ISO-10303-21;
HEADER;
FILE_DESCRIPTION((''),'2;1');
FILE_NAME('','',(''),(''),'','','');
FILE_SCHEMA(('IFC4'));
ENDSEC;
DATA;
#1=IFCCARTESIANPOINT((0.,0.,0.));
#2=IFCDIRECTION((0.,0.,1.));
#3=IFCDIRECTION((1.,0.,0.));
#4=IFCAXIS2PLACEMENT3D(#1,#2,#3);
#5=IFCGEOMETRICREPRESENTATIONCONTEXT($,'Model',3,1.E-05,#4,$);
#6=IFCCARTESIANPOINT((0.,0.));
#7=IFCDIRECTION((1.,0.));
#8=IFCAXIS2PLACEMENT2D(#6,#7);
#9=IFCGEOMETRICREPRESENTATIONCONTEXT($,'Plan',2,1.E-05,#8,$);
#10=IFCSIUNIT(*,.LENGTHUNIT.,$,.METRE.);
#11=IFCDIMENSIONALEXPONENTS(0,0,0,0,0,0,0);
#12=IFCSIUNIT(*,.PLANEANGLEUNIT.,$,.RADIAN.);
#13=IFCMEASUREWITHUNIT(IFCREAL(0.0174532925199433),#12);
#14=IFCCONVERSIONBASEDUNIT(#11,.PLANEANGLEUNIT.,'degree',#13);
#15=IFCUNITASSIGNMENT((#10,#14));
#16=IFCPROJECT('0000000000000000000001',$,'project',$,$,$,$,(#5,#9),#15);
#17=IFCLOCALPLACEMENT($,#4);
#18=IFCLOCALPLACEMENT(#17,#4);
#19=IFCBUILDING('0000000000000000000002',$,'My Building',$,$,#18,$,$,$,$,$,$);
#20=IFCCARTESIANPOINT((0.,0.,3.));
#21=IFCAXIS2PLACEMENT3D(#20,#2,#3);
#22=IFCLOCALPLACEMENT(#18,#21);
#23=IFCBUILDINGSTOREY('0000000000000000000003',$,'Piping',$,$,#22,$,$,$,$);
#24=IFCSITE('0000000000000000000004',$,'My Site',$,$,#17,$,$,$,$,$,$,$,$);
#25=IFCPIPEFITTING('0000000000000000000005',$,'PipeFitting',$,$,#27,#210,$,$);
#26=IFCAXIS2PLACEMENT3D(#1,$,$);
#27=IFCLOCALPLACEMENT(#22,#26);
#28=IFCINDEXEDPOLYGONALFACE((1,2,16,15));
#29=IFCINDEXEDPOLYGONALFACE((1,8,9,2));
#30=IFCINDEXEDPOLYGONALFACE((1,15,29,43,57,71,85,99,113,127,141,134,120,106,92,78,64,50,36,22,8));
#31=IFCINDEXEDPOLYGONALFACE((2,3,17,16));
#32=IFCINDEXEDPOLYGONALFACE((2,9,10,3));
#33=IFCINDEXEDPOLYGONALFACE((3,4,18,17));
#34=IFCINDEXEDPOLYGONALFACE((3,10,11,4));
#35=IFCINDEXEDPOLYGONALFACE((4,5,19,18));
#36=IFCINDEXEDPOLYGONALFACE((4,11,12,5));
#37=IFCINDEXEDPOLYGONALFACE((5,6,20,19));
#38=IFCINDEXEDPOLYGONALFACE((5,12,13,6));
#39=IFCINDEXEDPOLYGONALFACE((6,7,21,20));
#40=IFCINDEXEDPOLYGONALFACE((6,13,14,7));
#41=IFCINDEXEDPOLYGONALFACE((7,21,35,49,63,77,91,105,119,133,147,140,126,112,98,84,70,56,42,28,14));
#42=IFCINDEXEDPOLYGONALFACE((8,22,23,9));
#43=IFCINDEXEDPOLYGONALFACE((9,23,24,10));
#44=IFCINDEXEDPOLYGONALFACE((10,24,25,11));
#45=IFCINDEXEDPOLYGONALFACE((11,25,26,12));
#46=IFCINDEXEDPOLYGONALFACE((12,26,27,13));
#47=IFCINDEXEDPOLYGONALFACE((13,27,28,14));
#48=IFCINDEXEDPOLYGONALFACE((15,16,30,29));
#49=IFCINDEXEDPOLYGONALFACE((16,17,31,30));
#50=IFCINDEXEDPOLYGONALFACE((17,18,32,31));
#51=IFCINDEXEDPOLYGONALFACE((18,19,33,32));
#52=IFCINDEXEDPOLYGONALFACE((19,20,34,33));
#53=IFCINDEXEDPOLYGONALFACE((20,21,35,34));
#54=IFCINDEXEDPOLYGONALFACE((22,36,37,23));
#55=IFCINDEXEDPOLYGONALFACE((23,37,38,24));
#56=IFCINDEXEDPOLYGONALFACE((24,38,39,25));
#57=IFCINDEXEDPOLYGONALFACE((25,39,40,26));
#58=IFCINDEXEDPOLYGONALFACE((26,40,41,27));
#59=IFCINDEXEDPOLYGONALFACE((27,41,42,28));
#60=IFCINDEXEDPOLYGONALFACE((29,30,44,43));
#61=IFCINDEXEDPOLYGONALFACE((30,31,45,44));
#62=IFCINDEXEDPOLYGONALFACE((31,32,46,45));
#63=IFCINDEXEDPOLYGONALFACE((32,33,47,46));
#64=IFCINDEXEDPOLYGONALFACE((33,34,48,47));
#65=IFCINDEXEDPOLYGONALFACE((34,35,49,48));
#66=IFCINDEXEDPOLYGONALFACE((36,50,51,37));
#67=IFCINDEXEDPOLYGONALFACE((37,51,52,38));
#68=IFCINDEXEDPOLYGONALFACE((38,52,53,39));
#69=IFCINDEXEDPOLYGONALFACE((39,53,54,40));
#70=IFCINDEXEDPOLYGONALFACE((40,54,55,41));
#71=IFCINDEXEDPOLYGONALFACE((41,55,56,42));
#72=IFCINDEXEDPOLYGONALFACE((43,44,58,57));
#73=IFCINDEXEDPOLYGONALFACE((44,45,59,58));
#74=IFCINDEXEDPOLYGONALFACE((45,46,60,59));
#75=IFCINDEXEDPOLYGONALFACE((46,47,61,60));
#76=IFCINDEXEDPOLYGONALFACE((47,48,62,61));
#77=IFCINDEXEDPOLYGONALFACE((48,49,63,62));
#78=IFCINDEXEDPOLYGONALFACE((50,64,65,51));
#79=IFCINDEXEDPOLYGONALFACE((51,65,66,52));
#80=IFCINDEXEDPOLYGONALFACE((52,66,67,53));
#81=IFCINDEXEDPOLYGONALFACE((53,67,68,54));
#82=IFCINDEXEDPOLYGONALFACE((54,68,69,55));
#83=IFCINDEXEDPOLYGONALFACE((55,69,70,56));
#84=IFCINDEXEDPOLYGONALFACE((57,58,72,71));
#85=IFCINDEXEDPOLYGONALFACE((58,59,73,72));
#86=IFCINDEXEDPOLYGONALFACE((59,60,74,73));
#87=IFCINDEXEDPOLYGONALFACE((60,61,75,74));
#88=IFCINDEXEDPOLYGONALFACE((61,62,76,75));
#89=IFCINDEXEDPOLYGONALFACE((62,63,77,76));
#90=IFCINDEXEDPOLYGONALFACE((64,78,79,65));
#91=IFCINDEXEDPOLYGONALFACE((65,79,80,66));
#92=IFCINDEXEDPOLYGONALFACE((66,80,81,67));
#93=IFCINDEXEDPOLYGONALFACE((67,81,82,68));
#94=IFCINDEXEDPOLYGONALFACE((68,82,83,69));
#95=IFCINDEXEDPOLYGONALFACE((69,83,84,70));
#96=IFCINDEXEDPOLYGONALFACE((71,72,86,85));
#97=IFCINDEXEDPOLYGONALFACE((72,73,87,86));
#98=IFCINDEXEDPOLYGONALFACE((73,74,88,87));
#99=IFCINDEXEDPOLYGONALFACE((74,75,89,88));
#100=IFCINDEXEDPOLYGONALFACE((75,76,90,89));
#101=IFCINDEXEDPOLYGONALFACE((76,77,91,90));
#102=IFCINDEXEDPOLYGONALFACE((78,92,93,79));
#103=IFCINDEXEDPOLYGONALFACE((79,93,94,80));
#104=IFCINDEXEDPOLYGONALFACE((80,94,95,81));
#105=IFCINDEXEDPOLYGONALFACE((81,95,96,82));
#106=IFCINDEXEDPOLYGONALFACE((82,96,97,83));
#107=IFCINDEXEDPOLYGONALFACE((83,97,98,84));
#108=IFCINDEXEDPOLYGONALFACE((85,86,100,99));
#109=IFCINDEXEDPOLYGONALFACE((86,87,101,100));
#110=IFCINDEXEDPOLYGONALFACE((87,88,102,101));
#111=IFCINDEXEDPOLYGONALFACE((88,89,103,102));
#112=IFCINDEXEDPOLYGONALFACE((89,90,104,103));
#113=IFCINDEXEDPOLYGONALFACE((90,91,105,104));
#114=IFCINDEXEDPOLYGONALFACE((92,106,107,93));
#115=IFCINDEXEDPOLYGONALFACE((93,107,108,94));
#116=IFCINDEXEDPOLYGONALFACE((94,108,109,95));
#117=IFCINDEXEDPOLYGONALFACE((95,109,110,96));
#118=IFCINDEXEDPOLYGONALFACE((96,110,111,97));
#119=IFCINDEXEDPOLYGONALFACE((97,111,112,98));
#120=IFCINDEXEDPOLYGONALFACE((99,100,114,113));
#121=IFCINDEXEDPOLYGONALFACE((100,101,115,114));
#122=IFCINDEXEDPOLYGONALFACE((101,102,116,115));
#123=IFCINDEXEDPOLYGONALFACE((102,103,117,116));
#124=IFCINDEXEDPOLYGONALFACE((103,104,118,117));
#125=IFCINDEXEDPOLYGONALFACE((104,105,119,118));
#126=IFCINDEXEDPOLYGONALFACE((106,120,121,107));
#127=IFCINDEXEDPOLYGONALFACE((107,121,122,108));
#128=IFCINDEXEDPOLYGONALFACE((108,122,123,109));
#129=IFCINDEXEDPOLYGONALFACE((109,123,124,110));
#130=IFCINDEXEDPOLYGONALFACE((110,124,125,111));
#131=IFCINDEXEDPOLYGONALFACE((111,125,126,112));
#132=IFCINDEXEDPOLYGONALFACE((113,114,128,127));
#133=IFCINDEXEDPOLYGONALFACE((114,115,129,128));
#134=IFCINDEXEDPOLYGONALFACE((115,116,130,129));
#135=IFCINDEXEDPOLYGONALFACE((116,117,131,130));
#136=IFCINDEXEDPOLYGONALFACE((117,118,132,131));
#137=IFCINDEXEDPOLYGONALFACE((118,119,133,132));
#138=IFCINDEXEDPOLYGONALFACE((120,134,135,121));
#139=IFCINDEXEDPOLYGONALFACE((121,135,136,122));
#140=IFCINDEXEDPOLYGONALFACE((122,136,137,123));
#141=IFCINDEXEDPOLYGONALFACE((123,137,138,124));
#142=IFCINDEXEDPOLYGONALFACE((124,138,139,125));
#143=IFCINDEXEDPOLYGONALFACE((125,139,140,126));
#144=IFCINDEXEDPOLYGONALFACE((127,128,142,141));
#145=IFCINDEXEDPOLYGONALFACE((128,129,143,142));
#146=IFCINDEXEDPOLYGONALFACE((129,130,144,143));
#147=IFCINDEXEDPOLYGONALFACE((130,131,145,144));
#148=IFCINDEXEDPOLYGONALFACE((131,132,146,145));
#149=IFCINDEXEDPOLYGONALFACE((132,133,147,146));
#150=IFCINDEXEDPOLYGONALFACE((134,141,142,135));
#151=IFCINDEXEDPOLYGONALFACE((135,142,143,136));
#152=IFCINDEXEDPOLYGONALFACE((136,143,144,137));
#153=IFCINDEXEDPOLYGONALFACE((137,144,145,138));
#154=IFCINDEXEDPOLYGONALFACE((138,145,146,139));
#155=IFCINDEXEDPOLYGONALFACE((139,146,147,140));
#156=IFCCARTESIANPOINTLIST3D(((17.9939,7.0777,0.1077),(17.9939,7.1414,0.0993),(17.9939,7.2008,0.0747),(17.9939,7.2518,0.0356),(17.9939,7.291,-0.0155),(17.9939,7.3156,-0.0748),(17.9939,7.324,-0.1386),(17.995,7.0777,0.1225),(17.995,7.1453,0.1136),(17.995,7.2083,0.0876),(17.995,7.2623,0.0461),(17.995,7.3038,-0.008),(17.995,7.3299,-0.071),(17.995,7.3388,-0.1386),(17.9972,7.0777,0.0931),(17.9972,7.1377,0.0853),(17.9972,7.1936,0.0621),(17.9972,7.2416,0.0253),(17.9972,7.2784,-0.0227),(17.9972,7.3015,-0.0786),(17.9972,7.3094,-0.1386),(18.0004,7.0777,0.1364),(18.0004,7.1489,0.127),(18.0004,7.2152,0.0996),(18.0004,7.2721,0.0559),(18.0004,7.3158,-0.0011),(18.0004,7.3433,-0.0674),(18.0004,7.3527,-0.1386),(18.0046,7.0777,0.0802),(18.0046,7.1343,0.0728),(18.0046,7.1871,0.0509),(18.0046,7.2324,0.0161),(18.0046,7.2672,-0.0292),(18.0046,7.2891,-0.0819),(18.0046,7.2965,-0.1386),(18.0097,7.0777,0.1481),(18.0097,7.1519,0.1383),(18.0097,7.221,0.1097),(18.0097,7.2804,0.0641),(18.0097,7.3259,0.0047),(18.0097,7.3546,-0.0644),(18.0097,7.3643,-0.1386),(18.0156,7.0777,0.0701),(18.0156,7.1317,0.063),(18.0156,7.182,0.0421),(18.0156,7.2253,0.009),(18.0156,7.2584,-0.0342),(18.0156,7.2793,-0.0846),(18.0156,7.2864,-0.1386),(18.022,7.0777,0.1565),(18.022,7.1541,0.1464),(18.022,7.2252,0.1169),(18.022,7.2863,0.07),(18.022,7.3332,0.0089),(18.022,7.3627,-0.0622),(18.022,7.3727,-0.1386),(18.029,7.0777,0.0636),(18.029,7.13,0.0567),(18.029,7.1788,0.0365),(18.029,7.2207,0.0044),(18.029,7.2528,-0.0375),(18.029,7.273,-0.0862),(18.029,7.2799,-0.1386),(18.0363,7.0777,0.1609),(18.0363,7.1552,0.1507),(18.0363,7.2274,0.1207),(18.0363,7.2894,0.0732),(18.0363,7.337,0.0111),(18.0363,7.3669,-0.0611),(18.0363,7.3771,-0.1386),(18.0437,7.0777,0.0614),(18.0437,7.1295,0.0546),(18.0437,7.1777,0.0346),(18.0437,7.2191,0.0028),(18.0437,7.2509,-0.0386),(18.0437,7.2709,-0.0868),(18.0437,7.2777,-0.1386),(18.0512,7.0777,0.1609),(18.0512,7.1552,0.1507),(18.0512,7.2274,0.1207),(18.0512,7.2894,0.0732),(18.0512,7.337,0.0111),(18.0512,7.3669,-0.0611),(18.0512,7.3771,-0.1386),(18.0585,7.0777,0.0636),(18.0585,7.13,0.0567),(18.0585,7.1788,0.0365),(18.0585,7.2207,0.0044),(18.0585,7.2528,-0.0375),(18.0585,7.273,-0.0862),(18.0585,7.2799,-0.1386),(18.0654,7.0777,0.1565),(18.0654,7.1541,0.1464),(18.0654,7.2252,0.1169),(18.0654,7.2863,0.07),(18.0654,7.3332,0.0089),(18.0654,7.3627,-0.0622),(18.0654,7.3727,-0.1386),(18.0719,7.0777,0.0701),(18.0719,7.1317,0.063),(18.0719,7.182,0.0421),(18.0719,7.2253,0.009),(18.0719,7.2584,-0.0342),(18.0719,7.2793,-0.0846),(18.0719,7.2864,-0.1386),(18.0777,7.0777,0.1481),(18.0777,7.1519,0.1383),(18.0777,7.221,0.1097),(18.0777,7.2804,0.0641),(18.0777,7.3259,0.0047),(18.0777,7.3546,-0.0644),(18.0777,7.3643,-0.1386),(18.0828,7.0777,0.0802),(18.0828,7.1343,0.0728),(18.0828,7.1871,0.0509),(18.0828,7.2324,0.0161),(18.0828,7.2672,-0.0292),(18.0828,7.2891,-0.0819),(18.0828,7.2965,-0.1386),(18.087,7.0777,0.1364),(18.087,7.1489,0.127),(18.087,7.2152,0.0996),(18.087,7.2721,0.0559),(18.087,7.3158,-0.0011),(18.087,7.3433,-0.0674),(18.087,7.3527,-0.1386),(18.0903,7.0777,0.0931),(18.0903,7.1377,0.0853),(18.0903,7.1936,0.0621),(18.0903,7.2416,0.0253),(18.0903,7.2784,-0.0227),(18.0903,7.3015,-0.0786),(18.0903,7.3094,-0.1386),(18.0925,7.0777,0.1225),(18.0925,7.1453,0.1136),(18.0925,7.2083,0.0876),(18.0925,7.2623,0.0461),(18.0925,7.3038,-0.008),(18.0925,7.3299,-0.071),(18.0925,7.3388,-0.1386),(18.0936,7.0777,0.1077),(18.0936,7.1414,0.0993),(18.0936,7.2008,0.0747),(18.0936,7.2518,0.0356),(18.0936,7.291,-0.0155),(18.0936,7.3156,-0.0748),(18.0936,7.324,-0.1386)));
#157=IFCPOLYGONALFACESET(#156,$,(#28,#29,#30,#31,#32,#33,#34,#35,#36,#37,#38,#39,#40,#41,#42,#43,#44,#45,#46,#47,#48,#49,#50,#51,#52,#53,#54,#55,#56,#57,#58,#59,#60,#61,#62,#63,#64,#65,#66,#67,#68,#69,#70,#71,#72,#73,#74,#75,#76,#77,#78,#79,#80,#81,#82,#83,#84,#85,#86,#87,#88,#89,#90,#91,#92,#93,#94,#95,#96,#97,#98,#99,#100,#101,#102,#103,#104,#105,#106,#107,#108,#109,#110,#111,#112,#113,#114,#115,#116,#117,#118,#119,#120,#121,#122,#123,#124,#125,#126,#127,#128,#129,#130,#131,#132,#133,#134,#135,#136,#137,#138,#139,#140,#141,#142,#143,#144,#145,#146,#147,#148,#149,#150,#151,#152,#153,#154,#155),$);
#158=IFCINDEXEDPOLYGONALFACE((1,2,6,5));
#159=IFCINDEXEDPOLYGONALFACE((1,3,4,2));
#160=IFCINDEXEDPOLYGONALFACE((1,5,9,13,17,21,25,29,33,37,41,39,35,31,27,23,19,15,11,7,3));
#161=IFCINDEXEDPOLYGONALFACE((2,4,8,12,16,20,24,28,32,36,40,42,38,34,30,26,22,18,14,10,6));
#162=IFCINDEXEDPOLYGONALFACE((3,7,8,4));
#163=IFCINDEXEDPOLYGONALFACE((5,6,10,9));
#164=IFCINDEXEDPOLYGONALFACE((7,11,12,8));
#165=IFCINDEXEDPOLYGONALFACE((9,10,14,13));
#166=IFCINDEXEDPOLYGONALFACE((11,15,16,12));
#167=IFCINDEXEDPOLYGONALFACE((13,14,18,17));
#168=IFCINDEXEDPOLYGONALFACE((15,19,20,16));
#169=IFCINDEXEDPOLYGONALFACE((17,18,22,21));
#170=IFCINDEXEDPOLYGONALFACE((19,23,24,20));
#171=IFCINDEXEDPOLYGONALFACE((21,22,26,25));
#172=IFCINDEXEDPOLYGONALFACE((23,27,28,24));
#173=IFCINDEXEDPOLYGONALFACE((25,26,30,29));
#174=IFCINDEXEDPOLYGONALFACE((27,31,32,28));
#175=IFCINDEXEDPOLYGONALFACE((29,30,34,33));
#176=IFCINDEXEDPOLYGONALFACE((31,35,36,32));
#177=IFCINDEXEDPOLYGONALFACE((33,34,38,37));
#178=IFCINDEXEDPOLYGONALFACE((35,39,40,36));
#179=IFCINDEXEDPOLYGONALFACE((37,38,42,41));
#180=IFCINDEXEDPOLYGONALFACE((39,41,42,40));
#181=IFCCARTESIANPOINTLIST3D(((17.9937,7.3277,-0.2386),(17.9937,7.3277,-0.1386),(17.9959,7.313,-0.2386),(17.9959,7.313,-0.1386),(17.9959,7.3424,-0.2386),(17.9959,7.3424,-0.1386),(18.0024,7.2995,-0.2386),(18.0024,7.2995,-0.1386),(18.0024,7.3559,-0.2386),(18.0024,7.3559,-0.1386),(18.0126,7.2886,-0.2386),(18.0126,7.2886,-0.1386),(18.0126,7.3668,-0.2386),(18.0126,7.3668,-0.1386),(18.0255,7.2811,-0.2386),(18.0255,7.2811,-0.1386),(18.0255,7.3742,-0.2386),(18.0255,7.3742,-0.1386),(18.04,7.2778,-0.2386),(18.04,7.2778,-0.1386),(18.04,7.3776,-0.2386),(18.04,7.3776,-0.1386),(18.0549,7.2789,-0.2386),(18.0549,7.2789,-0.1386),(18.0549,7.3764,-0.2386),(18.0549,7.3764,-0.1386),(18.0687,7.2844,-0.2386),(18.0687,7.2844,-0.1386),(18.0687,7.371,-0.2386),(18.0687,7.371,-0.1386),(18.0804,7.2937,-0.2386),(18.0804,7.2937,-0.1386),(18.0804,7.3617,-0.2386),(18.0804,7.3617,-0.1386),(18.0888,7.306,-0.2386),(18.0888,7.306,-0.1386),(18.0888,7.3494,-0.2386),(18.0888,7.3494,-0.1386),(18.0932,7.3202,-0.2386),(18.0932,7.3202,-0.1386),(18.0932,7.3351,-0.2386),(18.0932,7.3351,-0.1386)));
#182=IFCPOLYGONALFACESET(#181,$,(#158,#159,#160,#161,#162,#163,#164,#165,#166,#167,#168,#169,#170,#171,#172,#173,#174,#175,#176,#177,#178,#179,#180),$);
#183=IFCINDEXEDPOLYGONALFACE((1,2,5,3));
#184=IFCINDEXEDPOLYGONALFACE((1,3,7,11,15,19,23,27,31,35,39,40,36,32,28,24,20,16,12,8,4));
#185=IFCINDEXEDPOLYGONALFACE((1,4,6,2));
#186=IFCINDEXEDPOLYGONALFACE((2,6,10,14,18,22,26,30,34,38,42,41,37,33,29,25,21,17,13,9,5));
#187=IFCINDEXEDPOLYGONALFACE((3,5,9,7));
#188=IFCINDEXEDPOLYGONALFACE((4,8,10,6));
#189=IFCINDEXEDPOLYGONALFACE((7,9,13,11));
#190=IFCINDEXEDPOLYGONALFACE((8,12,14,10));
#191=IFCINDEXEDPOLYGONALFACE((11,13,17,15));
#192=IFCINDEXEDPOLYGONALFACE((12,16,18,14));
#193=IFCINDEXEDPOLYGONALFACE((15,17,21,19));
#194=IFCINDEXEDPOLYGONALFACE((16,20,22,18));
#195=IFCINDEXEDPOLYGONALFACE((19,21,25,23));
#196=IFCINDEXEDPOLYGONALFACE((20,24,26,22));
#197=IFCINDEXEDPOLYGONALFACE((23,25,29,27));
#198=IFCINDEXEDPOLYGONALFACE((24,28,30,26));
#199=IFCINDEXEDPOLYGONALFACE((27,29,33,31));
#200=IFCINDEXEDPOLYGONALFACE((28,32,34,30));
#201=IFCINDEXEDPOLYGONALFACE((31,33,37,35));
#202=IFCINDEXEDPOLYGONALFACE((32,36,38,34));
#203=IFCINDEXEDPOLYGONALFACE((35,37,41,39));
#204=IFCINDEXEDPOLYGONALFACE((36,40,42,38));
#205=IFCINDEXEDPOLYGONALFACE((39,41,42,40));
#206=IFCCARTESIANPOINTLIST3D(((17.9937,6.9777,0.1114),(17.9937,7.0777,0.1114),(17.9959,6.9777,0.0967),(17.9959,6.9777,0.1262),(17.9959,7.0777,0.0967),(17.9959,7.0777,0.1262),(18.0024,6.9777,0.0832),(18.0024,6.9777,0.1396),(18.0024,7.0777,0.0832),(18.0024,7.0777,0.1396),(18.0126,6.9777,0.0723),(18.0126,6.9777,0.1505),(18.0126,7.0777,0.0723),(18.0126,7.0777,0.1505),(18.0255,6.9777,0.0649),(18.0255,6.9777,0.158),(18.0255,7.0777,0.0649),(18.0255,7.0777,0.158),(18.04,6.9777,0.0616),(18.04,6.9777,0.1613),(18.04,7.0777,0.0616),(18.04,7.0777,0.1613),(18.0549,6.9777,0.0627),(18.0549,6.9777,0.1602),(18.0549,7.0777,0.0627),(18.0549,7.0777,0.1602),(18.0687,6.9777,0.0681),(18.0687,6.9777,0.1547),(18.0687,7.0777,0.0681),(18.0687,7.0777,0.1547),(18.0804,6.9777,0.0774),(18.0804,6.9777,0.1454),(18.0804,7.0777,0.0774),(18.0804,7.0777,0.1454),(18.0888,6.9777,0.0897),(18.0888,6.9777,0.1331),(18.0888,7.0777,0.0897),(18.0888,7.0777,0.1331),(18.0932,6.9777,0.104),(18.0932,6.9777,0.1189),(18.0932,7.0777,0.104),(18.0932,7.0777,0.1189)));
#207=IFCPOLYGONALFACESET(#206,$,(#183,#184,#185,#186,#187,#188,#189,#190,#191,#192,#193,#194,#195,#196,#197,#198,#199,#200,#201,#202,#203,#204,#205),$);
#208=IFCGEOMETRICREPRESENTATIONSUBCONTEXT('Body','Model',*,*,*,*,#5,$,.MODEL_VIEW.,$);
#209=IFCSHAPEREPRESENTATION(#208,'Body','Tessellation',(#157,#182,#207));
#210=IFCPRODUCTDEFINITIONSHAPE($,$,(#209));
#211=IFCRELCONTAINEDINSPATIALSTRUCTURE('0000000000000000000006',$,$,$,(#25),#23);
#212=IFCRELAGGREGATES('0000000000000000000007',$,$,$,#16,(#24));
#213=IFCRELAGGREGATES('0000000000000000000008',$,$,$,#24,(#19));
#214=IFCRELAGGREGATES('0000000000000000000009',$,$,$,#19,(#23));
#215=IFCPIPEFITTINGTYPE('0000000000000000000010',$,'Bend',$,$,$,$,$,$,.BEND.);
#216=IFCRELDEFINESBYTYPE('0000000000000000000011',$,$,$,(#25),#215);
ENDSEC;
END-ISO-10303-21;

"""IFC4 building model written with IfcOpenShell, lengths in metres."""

from ifc_helpers import new_model, entity, si_unit, converted_unit, frame, origin_with_axes, origin_2d_with_axis, place, context, subcontext, project, spatial, circle, extrude, source, transform, mapped, type_object, type_shapes, element, save


model = new_model("IFC4")

# Units and contexts
model_context = context("Model", 3, precision=1e-05, world=origin_with_axes())
plan_context = context("Plan", 2, precision=1e-05, world=origin_2d_with_axis())
body_context = subcontext(model_context, "Body", "Model", "MODEL_VIEW")
ifc_project = project(units=[si_unit("LENGTHUNIT", "METRE"), converted_unit("PLANEANGLEUNIT", "degree", entity("IfcReal", 0.0174532925199433), si_unit("PLANEANGLEUNIT", "RADIAN"), dimensions=[0, 0, 0, 0, 0, 0, 0])], contexts=[model_context, plan_context])

# Site, building, storey
site_placement = place(None, origin_with_axes())
site = spatial("IfcSite", under=ifc_project, at=site_placement, Name="My Site")
building_placement = place(site_placement, origin_with_axes())
building = spatial("IfcBuilding", under=site, at=building_placement, Name="My Building")
storey_placement = place(building_placement, frame((0.0, 0.0, 3.0), z_axis=(0.0, 0.0, 1.0), x_axis=(1.0, 0.0, 0.0)))
storey = spatial("IfcBuildingStorey", under=building, at=storey_placement, Name="Piping")

# Pipe fitting
pipe_fitting_type_1 = type_object("IfcPipeFittingType", Name="Bend", PredefinedType="BEND")
shared_shape = source(origin_with_axes(), body_context, "Body", "SolidModel", [
    entity("IfcSweptDiskSolid", entity("IfcIndexedPolyCurve", entity("IfcCartesianPointList3D", [[0.0, 0.0, -0.1], [0.0, -0.0732, -0.2768], [0.0, -0.25, -0.35]]), [entity("IfcArcIndex", [1, 2, 3])]), 0.05),
    extrude(circle(Radius=0.05), origin_with_axes(), (0.0, 0.0, -1.0), 0.1),
    extrude(circle(Radius=0.05), frame((0.0, -0.25, -0.35), z_axis=(0.0, -1.0, 0.0), x_axis=(1.0, 0.0, 0.0)), (0.0, 0.0, 1.0), 0.1),
])
type_shapes(pipe_fitting_type_1, [shared_shape])
for number, where, z_axis, x_axis, name in (
    (1, (18.0437, 7.3277, -0.2386), (0.0, 0.0, -1.0), (-1.0, 0.0, 0.0), "PipeFitting"),
):
    element("IfcPipeFitting", number, at=place(storey_placement, frame(where, z_axis=z_axis, x_axis=x_axis)), inside=storey, type_object=pipe_fitting_type_1, Name=name, context=body_context, shape_type="MappedRepresentation", body=[
        mapped(shared_shape, transform((0.0, 0.0, 0.0), x_axis=(1.0, 0.0, 0.0), y_axis=(0.0, 1.0, 0.0), z_axis=(0.0, 0.0, 1.0), scale=1.0)),
    ])

save(model, "model.ifc")
